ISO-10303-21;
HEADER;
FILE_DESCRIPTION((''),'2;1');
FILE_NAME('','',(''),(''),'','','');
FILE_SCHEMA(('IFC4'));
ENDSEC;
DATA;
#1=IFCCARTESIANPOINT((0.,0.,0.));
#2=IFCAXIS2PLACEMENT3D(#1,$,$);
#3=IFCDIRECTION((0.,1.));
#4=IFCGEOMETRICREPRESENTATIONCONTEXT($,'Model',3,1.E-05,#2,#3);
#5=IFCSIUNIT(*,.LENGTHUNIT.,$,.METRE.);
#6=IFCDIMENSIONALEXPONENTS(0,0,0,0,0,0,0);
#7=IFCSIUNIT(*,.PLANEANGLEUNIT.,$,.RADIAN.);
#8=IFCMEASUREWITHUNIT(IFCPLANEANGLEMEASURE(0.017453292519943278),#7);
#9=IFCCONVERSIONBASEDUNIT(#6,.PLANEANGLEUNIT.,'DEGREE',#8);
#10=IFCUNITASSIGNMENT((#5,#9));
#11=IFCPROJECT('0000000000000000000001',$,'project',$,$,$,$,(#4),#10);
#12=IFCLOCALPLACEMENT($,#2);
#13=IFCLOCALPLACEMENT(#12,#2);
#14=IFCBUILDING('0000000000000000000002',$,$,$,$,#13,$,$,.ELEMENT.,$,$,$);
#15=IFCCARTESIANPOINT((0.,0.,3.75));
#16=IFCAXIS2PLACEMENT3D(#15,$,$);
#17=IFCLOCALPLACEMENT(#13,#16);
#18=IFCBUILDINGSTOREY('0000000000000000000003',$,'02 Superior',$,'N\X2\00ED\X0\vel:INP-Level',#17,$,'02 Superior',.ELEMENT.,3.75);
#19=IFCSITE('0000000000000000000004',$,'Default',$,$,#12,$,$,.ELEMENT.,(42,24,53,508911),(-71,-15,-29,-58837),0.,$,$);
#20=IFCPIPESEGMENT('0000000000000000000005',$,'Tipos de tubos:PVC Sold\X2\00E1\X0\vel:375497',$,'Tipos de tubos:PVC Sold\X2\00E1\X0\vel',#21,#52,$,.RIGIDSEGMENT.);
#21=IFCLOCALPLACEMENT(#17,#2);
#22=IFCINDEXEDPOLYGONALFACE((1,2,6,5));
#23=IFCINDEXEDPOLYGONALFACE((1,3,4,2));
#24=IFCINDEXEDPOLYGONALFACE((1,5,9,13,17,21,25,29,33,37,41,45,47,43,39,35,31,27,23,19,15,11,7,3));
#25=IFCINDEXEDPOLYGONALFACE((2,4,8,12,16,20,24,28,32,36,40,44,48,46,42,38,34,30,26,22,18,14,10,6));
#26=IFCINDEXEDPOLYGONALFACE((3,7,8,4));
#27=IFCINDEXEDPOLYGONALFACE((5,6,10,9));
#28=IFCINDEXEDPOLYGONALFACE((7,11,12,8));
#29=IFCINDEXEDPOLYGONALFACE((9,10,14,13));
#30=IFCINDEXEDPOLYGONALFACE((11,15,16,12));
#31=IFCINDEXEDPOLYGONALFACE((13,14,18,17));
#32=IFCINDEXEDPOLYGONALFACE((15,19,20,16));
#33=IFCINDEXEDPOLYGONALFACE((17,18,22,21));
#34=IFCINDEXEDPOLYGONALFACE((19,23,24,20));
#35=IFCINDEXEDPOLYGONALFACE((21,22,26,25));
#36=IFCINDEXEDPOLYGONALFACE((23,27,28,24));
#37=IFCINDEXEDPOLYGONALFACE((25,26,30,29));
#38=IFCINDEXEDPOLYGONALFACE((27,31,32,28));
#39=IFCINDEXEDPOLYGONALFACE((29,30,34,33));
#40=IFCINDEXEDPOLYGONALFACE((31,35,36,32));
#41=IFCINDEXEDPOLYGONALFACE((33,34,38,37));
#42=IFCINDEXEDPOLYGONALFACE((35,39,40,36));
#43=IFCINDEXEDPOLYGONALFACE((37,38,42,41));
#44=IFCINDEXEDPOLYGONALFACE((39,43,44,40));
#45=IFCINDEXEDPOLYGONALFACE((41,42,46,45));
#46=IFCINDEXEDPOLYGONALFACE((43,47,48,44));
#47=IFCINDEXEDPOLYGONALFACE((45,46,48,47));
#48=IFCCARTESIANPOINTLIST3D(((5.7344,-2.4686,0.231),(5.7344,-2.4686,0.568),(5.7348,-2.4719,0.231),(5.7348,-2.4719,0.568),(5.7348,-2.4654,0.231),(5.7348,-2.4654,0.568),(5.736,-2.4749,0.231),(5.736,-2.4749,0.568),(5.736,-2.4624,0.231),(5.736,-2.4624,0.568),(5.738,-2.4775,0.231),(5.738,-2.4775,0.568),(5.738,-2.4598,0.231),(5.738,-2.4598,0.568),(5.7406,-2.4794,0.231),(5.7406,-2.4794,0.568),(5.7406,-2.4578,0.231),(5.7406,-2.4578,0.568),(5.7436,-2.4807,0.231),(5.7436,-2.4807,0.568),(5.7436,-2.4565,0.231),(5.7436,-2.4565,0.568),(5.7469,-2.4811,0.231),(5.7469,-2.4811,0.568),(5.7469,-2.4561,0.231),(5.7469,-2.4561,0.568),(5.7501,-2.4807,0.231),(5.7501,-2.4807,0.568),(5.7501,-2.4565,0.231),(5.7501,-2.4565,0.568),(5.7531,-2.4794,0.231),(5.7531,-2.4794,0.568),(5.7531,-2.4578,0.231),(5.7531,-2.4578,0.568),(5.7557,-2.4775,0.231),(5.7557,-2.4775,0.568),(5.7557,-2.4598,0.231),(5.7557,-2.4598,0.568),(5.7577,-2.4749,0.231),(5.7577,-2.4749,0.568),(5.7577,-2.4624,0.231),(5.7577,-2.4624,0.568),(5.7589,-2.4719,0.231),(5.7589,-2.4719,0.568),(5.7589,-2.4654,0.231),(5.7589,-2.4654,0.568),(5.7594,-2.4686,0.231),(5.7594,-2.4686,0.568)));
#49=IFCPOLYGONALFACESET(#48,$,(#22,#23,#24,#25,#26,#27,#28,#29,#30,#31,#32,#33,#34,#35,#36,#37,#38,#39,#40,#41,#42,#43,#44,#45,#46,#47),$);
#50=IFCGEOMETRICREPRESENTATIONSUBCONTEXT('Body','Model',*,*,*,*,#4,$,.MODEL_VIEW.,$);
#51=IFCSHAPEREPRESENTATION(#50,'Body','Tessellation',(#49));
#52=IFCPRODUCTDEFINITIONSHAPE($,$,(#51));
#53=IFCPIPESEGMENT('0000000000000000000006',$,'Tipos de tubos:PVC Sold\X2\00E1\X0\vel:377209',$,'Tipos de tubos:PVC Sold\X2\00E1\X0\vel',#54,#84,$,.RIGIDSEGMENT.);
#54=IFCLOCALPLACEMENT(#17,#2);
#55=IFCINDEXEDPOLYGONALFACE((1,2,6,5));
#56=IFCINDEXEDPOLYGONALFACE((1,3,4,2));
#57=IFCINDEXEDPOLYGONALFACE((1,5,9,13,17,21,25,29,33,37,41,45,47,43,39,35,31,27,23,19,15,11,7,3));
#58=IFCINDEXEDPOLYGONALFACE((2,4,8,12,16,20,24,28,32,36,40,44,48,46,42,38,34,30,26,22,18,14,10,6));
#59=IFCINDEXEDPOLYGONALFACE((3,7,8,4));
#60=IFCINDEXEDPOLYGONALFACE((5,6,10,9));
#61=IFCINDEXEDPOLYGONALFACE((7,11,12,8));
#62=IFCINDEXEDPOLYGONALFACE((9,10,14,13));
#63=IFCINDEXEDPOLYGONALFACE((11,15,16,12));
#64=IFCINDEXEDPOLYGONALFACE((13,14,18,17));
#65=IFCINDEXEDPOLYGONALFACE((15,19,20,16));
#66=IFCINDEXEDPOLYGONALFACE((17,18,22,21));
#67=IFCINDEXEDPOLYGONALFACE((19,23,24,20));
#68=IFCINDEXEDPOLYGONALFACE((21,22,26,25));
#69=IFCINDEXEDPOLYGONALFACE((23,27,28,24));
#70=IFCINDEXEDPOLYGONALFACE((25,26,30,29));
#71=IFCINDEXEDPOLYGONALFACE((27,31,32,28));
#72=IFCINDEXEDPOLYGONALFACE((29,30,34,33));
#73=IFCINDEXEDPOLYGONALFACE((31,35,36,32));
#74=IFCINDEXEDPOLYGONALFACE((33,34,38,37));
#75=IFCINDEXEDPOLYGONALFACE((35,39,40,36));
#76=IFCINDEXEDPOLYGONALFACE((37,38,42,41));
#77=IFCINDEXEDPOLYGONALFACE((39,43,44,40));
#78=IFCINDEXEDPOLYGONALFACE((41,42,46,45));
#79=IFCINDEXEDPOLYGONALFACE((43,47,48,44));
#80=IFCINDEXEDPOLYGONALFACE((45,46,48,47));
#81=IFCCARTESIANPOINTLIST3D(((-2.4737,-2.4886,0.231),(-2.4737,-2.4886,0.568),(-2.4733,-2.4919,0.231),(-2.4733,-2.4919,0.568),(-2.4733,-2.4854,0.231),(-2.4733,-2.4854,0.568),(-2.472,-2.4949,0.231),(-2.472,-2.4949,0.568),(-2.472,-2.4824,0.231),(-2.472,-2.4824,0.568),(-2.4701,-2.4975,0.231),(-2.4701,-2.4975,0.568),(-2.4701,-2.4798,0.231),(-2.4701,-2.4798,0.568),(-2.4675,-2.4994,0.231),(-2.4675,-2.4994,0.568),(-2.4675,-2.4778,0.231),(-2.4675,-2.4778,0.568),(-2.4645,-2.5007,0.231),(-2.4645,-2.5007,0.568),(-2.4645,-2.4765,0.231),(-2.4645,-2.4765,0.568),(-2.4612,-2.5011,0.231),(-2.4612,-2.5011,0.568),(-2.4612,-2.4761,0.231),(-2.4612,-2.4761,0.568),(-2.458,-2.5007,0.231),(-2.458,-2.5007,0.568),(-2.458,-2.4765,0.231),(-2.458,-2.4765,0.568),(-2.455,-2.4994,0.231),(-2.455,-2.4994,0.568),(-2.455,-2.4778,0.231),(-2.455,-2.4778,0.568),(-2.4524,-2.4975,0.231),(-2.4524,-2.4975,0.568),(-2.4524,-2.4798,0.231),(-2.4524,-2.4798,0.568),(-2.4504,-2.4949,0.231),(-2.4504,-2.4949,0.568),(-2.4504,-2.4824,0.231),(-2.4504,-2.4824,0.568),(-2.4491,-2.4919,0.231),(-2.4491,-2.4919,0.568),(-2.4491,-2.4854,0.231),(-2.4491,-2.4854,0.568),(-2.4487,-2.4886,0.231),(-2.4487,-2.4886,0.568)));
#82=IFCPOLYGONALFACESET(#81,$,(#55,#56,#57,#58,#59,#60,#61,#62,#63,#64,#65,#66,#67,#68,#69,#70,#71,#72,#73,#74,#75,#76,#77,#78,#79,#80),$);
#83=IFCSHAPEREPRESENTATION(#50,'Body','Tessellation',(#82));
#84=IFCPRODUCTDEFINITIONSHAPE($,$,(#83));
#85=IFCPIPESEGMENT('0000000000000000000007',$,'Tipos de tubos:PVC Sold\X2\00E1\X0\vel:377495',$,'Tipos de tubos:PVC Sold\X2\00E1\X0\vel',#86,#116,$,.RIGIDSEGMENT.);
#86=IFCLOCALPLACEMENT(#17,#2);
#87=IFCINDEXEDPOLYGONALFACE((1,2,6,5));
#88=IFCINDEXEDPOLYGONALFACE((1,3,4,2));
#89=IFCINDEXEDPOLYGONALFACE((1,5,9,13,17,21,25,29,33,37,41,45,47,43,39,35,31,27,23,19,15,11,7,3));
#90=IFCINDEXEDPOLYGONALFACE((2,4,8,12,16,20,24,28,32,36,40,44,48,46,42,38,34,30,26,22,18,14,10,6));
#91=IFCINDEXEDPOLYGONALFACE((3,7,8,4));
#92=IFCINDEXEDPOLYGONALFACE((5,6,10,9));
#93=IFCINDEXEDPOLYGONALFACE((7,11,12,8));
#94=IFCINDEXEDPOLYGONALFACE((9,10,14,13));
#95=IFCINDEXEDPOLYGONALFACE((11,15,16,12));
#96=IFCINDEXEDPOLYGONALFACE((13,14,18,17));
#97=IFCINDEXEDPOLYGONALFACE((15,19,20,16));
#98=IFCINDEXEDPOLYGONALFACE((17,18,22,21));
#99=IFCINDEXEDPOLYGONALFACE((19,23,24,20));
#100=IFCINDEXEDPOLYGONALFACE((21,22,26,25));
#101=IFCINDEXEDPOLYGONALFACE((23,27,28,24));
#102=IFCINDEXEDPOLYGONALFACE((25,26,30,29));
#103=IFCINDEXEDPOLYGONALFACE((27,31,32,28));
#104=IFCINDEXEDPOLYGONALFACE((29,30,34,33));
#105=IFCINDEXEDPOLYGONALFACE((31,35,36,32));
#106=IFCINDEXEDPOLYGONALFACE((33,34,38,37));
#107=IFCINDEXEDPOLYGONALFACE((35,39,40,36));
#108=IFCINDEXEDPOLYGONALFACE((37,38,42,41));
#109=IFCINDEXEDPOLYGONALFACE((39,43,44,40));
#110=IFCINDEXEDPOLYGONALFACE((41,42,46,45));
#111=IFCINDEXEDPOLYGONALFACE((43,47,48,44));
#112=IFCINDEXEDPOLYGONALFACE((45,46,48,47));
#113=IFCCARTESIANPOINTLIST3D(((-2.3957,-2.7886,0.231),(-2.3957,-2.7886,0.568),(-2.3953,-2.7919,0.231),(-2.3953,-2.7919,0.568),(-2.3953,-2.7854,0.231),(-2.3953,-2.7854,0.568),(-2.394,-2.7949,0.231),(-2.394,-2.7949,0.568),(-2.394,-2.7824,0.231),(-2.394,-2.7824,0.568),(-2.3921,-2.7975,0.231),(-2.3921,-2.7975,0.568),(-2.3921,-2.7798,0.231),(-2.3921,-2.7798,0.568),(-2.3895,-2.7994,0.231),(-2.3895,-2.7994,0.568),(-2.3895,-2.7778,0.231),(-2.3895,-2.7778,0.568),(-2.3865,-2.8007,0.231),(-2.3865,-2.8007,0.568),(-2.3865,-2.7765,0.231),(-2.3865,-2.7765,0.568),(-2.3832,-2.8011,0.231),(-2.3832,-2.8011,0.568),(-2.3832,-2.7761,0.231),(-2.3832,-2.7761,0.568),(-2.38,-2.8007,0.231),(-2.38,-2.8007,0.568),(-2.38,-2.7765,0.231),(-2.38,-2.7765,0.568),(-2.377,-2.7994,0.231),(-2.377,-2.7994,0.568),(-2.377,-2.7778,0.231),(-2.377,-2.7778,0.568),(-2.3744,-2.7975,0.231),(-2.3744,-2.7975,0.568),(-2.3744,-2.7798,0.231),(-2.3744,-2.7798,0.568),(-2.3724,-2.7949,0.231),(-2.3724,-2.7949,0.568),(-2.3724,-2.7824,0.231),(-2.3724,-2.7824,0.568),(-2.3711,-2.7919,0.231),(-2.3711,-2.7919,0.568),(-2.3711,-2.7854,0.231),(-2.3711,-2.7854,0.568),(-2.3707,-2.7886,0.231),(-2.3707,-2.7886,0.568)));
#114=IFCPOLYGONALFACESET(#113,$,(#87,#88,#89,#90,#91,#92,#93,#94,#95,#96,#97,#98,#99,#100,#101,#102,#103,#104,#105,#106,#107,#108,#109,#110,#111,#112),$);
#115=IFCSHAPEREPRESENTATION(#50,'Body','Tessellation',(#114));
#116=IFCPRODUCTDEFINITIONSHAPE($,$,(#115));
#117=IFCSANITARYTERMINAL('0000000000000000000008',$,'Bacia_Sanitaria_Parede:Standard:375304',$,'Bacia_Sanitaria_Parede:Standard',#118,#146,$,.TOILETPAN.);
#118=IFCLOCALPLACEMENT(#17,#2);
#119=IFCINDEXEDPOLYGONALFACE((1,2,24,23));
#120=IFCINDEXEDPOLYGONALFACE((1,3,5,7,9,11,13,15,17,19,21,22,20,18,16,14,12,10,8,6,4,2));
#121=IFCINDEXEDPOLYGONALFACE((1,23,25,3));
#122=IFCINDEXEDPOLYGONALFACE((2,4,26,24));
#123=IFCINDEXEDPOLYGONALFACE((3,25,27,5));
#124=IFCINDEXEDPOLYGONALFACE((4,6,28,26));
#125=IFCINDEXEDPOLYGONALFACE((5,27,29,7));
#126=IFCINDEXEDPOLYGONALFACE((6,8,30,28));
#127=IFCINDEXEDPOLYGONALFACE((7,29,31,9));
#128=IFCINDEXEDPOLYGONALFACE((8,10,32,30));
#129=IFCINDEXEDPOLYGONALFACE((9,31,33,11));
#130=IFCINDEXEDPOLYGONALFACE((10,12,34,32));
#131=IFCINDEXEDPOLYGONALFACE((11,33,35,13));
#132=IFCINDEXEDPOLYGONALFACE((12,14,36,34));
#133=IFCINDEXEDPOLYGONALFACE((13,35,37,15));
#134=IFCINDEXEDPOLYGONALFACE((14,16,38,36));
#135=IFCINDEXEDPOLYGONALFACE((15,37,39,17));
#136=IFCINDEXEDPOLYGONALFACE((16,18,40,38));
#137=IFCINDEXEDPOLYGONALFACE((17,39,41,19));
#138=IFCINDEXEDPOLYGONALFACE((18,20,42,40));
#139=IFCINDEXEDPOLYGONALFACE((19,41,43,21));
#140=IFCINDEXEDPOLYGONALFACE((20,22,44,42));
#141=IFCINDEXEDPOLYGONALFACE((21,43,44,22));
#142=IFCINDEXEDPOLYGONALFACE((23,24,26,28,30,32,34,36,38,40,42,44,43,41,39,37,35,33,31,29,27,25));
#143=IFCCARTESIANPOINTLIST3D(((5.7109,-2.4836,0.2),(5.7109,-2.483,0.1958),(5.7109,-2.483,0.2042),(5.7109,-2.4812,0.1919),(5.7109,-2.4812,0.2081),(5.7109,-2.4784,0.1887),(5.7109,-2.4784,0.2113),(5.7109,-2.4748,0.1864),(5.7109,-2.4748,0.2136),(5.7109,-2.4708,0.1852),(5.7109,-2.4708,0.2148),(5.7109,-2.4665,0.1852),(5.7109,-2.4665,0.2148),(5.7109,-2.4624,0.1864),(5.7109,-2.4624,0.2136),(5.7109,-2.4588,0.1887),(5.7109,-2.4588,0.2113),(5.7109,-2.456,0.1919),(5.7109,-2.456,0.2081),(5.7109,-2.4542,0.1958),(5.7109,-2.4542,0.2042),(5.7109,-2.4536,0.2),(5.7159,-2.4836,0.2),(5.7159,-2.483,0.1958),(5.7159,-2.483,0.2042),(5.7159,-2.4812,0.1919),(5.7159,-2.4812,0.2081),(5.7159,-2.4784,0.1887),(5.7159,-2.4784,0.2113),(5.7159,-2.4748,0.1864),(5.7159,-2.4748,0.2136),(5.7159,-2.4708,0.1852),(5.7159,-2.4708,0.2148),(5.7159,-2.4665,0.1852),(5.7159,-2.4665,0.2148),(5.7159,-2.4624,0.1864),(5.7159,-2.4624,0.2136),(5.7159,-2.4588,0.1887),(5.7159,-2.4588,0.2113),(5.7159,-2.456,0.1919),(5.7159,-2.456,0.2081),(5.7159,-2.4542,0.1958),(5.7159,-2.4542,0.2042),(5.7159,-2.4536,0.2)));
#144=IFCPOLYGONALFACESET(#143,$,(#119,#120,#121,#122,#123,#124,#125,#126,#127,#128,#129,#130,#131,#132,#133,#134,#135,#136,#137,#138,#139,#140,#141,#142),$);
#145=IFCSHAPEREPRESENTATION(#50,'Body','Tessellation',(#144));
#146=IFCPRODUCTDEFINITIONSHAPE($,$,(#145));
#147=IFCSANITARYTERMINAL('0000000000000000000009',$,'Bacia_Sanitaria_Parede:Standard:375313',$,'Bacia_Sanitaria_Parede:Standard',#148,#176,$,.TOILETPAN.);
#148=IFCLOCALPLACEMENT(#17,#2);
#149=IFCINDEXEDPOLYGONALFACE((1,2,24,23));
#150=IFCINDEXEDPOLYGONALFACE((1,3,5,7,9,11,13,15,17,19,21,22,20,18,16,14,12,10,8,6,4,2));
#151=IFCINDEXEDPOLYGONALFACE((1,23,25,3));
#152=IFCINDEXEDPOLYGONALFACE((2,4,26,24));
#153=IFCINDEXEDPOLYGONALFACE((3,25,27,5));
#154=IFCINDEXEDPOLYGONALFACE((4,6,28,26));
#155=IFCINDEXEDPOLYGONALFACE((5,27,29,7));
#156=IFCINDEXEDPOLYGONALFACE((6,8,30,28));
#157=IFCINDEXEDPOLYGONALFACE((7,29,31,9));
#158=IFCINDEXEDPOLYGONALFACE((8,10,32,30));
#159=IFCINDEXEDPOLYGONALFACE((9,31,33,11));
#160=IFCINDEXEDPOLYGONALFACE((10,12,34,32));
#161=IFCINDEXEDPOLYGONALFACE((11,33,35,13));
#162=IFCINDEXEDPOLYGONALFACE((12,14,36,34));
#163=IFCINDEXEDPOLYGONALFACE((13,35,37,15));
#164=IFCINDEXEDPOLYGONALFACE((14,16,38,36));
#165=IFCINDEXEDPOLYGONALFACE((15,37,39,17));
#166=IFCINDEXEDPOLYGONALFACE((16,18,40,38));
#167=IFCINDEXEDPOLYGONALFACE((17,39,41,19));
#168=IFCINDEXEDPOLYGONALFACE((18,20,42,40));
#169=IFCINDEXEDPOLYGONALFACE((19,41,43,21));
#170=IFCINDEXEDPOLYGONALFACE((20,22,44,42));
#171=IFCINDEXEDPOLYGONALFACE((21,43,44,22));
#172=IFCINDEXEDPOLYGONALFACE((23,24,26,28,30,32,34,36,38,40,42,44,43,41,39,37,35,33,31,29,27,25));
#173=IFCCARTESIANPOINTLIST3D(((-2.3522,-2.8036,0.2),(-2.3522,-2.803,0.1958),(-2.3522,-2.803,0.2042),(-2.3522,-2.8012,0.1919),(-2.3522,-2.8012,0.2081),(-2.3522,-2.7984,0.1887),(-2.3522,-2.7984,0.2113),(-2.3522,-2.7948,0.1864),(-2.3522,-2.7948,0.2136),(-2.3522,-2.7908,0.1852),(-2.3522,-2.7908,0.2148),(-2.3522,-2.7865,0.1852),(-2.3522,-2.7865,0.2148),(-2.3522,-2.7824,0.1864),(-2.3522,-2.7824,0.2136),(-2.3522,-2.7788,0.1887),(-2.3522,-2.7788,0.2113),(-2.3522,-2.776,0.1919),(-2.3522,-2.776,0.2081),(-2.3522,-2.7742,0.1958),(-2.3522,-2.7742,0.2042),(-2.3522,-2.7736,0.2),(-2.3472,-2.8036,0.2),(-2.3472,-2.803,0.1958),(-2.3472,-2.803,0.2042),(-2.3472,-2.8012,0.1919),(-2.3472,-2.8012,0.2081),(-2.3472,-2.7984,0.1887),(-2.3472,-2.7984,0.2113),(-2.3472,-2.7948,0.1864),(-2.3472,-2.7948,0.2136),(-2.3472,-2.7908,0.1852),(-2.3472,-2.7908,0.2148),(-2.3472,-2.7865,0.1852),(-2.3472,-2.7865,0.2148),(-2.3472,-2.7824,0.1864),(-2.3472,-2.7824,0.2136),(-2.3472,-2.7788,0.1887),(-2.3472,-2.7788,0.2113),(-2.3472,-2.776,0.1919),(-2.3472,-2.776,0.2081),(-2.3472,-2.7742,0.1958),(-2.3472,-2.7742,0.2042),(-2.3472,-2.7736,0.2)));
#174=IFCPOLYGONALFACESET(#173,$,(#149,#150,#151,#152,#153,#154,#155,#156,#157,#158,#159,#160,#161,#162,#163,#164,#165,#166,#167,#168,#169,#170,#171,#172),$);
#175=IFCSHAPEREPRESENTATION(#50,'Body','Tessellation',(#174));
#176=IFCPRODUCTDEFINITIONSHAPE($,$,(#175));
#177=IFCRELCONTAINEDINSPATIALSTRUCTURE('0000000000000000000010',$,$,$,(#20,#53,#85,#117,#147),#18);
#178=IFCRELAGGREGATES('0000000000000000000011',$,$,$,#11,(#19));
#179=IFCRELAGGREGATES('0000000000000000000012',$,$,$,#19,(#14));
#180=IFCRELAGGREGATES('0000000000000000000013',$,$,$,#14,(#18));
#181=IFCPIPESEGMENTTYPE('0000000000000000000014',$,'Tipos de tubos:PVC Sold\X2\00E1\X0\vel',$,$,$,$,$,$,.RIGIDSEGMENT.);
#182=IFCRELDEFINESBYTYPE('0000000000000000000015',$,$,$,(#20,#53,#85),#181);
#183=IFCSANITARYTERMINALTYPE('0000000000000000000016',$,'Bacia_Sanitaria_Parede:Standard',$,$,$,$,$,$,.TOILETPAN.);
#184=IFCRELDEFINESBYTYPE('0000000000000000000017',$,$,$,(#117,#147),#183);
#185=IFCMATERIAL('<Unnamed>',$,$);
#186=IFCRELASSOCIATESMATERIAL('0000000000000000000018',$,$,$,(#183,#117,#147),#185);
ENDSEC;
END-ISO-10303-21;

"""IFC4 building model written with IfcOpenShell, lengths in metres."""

from ifc_helpers import new_model, entity, si_unit, converted_unit, direction, frame, origin, place, context, subcontext, project, spatial, arc, indexed_curve, outline, extrude, source, transform, mapped, material, type_object, type_shapes, element, save


model = new_model("IFC4")

# Units and contexts
model_context = context("Model", 3, precision=1e-05, world=origin(), true_north=direction((0.0, 1.0)))
body_context = subcontext(model_context, "Body", "Model", "MODEL_VIEW")
ifc_project = project(units=[si_unit("LENGTHUNIT", "METRE"), converted_unit("PLANEANGLEUNIT", "DEGREE", entity("IfcPlaneAngleMeasure", 0.017453292519943278), si_unit("PLANEANGLEUNIT", "RADIAN"), dimensions=[0, 0, 0, 0, 0, 0, 0])], contexts=[model_context])

# Site, building, storey
site_placement = place(None, origin())
site = spatial("IfcSite", under=ifc_project, at=site_placement, Name="Default", CompositionType="ELEMENT", RefLatitude=(42, 24, 53, 508911), RefLongitude=(-71, -15, -29, -58837), RefElevation=0.0)
building_placement = place(site_placement, origin())
building = spatial("IfcBuilding", under=site, at=building_placement, CompositionType="ELEMENT")
storey_placement = place(building_placement, frame((0.0, 0.0, 3.75)))
storey = spatial("IfcBuildingStorey", under=building, at=storey_placement, Name="02 Superior", ObjectType="Nível:INP-Level", LongName="02 Superior", CompositionType="ELEMENT", Elevation=3.75)

# Pipe segments
pipe_segment_type = type_object("IfcPipeSegmentType", Name="Tipos de tubos:PVC Soldável", PredefinedType="RIGIDSEGMENT")
pipe_segment_1_placement = place(storey_placement, origin())
element("IfcPipeSegment", 1, at=pipe_segment_1_placement, inside=storey, type_object=pipe_segment_type, Name="Tipos de tubos:PVC Soldável:375497", ObjectType="Tipos de tubos:PVC Soldável", PredefinedType="RIGIDSEGMENT", context=body_context, shape_type="SweptSolid", body=[
    extrude(outline(indexed_curve([(0.0125, 0.0), (0.0088, 0.0088), (0.0, 0.0125), (-0.0088, 0.0088), (-0.0125, 0.0), (-0.0088, -0.0088), (0.0, -0.0125), (0.0088, -0.0088)], segments=[arc(1, 2, 3), arc(3, 4, 5), arc(5, 6, 7), arc(7, 8, 1)], self_intersect=False)), frame((5.7469, -2.4686, 0.231)), (0.0, 0.0, 1.0), 0.337),
])
pipe_segment_2_placement = place(storey_placement, origin())
element("IfcPipeSegment", 2, at=pipe_segment_2_placement, inside=storey, type_object=pipe_segment_type, Name="Tipos de tubos:PVC Soldável:377209", ObjectType="Tipos de tubos:PVC Soldável", PredefinedType="RIGIDSEGMENT", context=body_context, shape_type="SweptSolid", body=[
    extrude(outline(indexed_curve([(0.0125, 0.0), (0.0088, 0.0088), (0.0, 0.0125), (-0.0088, 0.0088), (-0.0125, 0.0), (-0.0088, -0.0088), (0.0, -0.0125), (0.0088, -0.0088)], segments=[arc(1, 2, 3), arc(3, 4, 5), arc(5, 6, 7), arc(7, 8, 1)], self_intersect=False)), frame((-2.4612, -2.4886, 0.231)), (0.0, 0.0, 1.0), 0.337),
])
pipe_segment_3_placement = place(storey_placement, origin())
element("IfcPipeSegment", 3, at=pipe_segment_3_placement, inside=storey, type_object=pipe_segment_type, Name="Tipos de tubos:PVC Soldável:377495", ObjectType="Tipos de tubos:PVC Soldável", PredefinedType="RIGIDSEGMENT", context=body_context, shape_type="SweptSolid", body=[
    extrude(outline(indexed_curve([(0.0125, 0.0), (0.0088, 0.0088), (0.0, 0.0125), (-0.0088, 0.0088), (-0.0125, 0.0), (-0.0088, -0.0088), (0.0, -0.0125), (0.0088, -0.0088)], segments=[arc(1, 2, 3), arc(3, 4, 5), arc(5, 6, 7), arc(7, 8, 1)], self_intersect=False)), frame((-2.3832, -2.7886, 0.231)), (0.0, 0.0, 1.0), 0.337),
])

# Sanitary terminals
ifc_material = material(Name="<Unnamed>")
sanitary_terminal_type = type_object("IfcSanitaryTerminalType", Name="Bacia_Sanitaria_Parede:Standard", PredefinedType="TOILETPAN", material=ifc_material)
shared_shape = source(origin(), body_context, "Body", "SweptSolid", [
    extrude(outline(indexed_curve([(-0.015, 0.0), (0.0, -0.015), (0.015, 0.0), (0.0, 0.015)], segments=[arc(1, 2, 3), arc(3, 4, 1)], self_intersect=False)), frame((0.15, -0.005, 0.2), z_axis=(0.0, 1.0, 0.0), x_axis=(1.0, 0.0, 0.0)), (0.0, 0.0, 1.0), 0.005),
])
type_shapes(sanitary_terminal_type, [shared_shape])
for number, where, z_axis, x_axis, name in (
    (4, (5.7109, -2.6186, 0.0), (0.0, 0.0, 1.0), (0.0, 1.0, 0.0), "Bacia_Sanitaria_Parede:Standard:375304"),
    (5, (-2.3472, -2.6386, 0.0), (0.0, 0.0, 1.0), (0.0, -1.0, 0.0), "Bacia_Sanitaria_Parede:Standard:375313"),
):
    element("IfcSanitaryTerminal", number, at=place(storey_placement, frame(where, z_axis=z_axis, x_axis=x_axis)), inside=storey, type_object=sanitary_terminal_type, material=ifc_material, Name=name, ObjectType="Bacia_Sanitaria_Parede:Standard", PredefinedType="TOILETPAN", context=body_context, shape_type="MappedRepresentation", body=[
        mapped(shared_shape, transform((0.0, 0.0, 0.0), scale=1.0)),
    ])

save(model, "model.ifc")
